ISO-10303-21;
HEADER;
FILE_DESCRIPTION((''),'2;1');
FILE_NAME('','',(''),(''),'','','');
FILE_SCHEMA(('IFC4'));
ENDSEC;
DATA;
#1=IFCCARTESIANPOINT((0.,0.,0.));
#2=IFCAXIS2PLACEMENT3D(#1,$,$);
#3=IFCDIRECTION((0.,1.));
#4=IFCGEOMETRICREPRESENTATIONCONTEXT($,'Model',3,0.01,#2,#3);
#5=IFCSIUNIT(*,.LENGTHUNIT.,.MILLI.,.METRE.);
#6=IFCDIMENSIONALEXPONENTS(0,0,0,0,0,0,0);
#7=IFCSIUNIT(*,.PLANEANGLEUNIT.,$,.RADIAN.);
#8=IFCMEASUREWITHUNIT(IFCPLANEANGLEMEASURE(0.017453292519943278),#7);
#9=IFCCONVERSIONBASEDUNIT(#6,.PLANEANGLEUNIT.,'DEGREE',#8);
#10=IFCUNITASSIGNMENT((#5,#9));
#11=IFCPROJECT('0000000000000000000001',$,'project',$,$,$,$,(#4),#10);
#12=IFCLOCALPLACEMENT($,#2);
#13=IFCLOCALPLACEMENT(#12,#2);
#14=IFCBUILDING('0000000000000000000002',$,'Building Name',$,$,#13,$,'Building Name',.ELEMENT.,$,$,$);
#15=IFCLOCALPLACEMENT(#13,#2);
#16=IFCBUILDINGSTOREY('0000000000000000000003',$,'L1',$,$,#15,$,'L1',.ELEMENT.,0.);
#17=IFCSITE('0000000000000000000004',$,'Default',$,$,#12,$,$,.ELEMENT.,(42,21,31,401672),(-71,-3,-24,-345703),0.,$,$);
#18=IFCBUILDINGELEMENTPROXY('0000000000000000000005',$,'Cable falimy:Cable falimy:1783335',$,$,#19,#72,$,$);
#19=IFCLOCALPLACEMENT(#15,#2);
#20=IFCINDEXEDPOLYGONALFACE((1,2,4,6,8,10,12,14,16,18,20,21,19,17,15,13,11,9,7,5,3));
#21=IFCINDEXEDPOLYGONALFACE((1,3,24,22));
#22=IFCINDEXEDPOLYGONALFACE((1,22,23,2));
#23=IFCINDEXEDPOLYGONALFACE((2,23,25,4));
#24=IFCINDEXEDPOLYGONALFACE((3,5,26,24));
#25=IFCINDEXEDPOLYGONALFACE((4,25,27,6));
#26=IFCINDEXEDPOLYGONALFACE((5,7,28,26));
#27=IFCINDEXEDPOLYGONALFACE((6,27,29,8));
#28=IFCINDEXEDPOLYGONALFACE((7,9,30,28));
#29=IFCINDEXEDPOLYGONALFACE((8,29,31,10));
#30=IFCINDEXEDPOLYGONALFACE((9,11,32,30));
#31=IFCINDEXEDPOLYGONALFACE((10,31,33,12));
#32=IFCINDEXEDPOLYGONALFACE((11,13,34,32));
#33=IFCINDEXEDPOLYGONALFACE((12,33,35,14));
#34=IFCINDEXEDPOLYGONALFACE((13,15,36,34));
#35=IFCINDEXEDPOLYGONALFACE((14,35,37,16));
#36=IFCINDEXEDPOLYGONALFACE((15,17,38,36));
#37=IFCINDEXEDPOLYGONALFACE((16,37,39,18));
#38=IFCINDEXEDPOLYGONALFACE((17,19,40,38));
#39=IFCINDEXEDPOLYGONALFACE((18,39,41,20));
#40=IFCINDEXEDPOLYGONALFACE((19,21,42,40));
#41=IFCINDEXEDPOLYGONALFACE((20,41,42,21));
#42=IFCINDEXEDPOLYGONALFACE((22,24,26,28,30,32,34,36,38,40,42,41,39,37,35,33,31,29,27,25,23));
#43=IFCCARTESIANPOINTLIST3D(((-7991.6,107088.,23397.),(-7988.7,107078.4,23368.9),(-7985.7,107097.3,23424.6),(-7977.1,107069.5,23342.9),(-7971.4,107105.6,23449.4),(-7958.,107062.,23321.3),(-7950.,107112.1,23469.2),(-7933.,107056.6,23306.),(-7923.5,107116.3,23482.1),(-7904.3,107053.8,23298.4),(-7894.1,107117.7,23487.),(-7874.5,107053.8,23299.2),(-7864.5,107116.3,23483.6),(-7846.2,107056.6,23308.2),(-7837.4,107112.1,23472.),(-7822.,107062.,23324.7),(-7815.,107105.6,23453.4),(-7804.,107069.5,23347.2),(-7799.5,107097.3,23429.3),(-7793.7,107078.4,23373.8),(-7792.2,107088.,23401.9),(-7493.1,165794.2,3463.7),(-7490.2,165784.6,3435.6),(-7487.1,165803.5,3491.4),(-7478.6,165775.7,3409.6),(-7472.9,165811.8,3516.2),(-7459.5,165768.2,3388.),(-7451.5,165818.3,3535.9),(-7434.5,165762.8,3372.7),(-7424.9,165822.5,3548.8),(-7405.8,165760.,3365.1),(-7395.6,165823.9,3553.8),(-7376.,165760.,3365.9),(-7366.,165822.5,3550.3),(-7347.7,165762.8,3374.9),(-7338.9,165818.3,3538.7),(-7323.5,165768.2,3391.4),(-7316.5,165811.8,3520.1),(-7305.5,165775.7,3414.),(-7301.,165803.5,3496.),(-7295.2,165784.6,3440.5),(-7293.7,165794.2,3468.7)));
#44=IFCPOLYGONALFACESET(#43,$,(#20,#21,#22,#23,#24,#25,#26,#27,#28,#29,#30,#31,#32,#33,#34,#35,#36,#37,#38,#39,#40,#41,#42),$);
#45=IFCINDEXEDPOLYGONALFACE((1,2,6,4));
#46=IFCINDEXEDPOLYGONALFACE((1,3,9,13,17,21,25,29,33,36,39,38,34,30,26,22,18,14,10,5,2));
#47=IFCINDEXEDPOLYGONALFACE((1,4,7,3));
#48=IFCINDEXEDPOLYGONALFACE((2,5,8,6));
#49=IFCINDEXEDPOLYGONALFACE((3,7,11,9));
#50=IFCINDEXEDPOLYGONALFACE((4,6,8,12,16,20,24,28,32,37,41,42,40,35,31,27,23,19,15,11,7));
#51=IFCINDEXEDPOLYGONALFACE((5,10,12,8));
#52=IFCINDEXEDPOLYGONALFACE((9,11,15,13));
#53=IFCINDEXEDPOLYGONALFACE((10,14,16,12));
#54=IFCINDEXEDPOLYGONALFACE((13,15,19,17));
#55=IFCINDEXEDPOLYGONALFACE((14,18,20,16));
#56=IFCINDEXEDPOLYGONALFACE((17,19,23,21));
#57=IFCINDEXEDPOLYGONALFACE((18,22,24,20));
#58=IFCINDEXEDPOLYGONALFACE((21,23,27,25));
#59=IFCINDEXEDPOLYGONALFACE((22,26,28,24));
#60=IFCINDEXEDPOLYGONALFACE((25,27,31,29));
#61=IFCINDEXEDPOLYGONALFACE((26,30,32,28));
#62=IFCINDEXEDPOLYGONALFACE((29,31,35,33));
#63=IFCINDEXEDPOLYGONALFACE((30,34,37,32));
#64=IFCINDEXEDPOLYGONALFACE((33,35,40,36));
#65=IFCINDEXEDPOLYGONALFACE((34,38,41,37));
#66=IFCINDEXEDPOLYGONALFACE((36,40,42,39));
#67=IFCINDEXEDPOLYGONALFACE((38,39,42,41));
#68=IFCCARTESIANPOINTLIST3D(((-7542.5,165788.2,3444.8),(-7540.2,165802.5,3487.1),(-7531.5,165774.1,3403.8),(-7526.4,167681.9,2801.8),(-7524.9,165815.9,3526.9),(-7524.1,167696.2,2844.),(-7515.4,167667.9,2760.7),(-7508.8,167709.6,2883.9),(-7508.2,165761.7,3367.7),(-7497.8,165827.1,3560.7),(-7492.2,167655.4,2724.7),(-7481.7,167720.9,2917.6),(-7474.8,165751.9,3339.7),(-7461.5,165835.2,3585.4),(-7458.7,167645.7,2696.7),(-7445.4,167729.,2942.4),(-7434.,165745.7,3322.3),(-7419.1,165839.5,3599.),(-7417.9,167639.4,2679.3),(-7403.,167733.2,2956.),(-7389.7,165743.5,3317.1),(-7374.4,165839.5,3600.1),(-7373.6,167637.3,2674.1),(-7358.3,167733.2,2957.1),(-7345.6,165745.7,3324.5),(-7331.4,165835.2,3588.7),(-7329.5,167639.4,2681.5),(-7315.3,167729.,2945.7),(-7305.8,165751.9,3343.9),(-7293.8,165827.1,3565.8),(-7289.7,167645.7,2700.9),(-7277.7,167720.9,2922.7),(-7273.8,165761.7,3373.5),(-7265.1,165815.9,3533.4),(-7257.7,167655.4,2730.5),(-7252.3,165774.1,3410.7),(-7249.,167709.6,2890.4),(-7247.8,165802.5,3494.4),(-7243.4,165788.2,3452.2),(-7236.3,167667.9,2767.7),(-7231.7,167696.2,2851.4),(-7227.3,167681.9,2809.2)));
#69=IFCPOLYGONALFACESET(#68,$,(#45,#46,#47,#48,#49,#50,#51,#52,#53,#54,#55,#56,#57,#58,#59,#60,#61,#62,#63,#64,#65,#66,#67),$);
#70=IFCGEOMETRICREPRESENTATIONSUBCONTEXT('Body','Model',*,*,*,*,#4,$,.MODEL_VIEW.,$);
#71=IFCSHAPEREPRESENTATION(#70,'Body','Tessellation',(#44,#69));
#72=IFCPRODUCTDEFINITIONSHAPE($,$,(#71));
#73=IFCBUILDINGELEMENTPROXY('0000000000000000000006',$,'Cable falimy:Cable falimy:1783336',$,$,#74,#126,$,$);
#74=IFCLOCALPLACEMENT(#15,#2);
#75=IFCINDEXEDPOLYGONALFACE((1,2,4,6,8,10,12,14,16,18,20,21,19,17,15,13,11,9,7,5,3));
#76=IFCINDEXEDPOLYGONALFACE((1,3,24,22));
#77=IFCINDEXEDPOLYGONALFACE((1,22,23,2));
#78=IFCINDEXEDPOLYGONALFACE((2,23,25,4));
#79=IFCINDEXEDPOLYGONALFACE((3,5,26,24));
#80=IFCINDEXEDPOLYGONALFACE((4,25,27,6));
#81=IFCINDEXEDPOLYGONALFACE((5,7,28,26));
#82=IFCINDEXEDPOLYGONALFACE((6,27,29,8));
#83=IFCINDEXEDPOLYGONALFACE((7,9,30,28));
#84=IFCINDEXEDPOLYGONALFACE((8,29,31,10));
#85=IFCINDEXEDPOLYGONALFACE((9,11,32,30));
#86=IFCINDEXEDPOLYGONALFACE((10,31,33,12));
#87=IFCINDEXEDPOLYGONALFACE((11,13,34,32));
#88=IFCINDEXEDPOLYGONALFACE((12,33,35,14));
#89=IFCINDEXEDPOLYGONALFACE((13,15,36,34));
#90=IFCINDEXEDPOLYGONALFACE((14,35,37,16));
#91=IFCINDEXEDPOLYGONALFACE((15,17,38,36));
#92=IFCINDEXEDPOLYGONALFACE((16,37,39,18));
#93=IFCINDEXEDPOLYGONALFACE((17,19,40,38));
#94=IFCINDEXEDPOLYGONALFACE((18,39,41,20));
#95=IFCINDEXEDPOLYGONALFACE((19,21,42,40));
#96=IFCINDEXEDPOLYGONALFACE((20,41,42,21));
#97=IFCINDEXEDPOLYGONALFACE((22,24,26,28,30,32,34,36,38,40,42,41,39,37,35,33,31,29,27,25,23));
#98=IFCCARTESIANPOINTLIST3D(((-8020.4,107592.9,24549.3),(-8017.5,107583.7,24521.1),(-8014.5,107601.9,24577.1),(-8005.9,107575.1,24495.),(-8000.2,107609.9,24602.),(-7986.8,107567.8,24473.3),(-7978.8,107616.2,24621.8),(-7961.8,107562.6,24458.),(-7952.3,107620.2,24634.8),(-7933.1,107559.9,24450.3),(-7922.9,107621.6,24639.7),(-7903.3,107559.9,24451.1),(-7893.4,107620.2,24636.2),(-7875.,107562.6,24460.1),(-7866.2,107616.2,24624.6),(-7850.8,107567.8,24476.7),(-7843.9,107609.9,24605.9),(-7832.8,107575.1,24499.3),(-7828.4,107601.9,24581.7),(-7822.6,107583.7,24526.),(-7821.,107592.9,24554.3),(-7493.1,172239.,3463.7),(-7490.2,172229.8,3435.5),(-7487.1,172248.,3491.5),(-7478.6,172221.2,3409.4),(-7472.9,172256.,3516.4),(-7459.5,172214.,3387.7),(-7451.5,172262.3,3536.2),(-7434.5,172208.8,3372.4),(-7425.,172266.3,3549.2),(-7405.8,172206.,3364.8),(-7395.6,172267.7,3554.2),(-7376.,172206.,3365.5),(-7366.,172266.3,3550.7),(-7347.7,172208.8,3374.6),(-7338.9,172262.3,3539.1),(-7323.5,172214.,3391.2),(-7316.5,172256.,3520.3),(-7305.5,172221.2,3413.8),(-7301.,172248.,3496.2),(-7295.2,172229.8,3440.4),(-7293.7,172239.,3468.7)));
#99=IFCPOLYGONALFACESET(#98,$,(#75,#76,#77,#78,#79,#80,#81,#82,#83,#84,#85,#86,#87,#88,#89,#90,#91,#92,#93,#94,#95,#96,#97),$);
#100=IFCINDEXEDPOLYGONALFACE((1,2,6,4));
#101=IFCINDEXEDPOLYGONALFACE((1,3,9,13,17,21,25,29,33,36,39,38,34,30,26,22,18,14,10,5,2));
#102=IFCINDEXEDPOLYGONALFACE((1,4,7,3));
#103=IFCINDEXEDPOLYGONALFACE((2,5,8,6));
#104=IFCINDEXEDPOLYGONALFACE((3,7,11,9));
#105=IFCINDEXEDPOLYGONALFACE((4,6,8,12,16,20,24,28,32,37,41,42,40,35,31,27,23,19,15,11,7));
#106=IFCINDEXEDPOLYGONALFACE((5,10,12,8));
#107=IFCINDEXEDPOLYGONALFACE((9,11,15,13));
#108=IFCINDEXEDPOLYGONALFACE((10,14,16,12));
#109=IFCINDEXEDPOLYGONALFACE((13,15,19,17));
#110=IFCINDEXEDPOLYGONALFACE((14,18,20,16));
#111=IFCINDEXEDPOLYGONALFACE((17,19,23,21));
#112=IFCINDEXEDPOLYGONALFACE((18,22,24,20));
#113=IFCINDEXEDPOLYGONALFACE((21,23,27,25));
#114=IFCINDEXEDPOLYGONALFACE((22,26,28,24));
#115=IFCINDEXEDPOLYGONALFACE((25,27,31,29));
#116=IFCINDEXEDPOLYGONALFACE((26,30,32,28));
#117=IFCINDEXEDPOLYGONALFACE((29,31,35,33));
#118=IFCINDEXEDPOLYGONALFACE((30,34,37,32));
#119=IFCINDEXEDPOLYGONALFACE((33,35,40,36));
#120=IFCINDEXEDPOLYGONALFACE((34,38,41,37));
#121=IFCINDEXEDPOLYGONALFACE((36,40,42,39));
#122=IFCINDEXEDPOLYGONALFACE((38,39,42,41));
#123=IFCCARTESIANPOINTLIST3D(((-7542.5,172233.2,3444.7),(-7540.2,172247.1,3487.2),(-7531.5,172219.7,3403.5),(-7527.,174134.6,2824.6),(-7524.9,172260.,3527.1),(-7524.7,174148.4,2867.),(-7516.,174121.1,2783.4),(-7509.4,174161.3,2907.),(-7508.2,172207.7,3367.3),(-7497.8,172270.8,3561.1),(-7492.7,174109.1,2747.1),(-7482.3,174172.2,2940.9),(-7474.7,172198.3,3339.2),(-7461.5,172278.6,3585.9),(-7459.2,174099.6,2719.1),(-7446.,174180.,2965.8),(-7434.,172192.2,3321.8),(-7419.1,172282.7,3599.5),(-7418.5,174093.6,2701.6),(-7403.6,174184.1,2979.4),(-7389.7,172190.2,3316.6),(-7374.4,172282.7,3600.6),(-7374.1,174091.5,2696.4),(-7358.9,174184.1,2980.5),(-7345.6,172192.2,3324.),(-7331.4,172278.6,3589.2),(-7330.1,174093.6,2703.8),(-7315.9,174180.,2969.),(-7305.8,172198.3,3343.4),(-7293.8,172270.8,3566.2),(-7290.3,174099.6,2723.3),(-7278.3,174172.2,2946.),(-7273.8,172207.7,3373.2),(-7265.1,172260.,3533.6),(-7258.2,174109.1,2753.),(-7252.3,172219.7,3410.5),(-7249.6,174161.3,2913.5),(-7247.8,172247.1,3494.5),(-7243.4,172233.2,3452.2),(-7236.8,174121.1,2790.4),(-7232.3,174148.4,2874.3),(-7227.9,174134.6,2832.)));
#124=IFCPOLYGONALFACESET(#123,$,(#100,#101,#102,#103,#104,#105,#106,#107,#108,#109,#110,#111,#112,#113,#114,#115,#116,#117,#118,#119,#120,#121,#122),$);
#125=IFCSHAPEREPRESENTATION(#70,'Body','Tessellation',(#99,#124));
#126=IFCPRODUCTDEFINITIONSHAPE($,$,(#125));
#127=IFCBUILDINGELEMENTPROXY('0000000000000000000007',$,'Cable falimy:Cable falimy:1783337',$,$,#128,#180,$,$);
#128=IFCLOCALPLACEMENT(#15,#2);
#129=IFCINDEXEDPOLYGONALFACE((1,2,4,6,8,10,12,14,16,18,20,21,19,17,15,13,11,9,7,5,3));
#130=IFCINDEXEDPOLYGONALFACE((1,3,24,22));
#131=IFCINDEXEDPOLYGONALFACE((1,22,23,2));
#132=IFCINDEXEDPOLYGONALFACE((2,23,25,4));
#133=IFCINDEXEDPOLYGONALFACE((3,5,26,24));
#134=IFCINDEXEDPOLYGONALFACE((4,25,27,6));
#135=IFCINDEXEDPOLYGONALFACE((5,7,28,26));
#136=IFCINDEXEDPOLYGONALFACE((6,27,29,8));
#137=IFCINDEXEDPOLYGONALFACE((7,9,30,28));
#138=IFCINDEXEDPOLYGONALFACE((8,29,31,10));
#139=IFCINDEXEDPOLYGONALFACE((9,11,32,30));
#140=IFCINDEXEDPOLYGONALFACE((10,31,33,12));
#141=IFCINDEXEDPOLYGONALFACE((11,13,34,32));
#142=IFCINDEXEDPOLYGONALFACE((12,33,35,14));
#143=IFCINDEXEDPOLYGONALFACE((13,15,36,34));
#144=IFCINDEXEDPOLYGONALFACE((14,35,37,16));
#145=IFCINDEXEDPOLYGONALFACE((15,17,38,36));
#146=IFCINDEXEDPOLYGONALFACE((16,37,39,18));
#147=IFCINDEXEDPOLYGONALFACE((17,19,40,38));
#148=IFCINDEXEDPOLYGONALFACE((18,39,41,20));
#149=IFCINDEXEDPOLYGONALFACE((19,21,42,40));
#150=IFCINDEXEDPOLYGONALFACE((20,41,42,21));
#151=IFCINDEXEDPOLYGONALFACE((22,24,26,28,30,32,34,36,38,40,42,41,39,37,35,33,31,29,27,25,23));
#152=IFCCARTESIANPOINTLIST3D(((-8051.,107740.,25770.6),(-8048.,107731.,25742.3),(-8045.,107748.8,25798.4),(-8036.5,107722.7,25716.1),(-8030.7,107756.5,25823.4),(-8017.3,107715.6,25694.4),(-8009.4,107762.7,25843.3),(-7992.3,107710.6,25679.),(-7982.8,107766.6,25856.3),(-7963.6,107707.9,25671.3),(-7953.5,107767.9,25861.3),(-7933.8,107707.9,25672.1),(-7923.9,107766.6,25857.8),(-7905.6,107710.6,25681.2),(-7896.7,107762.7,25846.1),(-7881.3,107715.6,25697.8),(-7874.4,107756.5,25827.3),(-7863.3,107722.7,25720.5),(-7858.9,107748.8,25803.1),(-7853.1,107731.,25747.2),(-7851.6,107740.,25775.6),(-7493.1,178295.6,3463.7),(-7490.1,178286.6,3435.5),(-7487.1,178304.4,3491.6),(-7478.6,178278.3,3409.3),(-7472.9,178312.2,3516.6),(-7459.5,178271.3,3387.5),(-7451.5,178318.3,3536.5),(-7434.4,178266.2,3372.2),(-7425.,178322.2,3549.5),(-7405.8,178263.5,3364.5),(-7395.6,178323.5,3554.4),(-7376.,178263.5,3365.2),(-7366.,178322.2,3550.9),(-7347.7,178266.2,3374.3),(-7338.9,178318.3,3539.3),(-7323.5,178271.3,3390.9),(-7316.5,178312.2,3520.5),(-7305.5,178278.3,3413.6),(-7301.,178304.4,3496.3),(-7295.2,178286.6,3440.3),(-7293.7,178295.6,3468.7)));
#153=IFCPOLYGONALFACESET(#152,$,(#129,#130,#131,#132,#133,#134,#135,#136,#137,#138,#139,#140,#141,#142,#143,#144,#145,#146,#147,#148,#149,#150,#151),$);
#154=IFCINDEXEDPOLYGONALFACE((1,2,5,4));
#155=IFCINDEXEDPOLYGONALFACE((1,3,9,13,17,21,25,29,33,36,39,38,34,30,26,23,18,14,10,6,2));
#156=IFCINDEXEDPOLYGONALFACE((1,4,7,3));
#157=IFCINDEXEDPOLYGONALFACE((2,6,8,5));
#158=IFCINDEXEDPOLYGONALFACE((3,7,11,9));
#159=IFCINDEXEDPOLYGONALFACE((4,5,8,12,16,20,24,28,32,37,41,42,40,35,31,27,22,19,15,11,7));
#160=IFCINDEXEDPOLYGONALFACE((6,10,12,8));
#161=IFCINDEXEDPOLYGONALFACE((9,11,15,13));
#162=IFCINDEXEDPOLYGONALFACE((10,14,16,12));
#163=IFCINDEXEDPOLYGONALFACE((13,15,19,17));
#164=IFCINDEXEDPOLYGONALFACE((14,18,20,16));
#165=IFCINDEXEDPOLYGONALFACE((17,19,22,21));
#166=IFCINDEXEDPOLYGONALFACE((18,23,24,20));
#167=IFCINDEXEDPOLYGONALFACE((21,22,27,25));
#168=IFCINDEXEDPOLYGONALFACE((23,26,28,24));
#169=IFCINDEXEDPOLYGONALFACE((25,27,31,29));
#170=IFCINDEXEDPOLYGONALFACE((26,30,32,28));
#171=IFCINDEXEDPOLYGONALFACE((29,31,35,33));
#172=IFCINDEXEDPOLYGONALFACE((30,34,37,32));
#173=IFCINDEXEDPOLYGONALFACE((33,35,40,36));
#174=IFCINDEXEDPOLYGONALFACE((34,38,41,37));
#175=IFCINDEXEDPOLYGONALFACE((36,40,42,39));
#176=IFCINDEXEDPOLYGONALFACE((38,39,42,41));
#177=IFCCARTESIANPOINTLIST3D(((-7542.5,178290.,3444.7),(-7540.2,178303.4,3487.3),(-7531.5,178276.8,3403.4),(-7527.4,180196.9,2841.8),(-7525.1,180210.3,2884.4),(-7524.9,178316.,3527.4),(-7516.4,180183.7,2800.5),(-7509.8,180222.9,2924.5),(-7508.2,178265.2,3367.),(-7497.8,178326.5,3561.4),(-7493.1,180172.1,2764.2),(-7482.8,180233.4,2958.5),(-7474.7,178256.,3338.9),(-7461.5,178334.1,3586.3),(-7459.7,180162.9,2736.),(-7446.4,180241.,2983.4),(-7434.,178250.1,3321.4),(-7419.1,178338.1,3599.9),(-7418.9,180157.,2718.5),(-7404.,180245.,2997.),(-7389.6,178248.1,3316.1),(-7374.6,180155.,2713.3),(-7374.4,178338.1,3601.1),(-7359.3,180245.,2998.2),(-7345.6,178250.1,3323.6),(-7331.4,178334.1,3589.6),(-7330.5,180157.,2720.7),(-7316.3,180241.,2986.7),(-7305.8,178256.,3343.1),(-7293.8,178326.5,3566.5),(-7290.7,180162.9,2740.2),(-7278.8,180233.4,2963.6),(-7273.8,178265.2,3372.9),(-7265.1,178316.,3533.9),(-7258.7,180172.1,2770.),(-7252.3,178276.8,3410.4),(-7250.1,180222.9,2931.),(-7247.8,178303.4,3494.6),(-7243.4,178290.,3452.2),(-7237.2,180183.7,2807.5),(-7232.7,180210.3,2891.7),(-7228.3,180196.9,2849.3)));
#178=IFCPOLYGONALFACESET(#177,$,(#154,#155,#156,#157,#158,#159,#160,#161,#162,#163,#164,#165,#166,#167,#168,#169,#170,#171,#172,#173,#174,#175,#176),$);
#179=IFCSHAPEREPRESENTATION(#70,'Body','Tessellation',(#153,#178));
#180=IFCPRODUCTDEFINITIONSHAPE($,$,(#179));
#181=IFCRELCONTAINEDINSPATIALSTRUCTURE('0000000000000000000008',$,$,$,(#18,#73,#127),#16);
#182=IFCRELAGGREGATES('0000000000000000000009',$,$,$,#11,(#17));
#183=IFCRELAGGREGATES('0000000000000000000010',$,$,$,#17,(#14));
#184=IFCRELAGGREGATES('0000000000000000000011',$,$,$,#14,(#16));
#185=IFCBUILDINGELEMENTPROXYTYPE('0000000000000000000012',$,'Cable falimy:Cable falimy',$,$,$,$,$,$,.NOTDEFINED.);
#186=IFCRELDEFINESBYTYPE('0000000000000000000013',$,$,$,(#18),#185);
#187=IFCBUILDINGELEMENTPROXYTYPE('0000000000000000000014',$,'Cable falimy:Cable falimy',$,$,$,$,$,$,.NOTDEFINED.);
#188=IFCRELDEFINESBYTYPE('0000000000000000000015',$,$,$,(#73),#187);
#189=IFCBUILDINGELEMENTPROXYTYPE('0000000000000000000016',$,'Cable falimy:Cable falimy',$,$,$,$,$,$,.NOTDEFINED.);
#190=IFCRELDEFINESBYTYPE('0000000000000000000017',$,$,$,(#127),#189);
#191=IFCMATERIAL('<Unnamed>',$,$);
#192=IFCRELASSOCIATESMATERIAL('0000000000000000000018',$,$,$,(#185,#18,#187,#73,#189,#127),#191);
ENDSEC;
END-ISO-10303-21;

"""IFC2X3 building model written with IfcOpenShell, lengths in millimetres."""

from ifc_helpers import new_model, entity, si_unit, converted_unit, direction, frame, frame_2d, origin, place, context, subcontext, project, spatial, circle, extrude, source, transform, mapped, material, type_object, type_shapes, element, save


model = new_model("IFC2X3")

# Units and contexts
model_context = context("Model", 3, precision=0.01, world=origin(), true_north=direction((0.0, 1.0)))
body_context = subcontext(model_context, "Body", "Model", "MODEL_VIEW")
ifc_project = project(units=[si_unit("LENGTHUNIT", "METRE", prefix="MILLI"), converted_unit("PLANEANGLEUNIT", "DEGREE", entity("IfcPlaneAngleMeasure", 0.017453292519943278), si_unit("PLANEANGLEUNIT", "RADIAN"), dimensions=[0, 0, 0, 0, 0, 0, 0])], contexts=[model_context])

# Site, building, storey
site_placement = place(None, origin())
site = spatial("IfcSite", under=ifc_project, at=site_placement, Name="Default", CompositionType="ELEMENT", RefLatitude=(42, 21, 31, 401672), RefLongitude=(-71, -3, -24, -345703), RefElevation=0.0)
building_placement = place(site_placement, origin())
building = spatial("IfcBuilding", under=site, at=building_placement, Name="Building Name", LongName="Building Name", CompositionType="ELEMENT")
storey_placement = place(building_placement, origin())
storey = spatial("IfcBuildingStorey", under=building, at=storey_placement, Name="L1", LongName="L1", CompositionType="ELEMENT", Elevation=0.0)

# Shared definitions
ifc_material = material(Name="<Unnamed>")

# Building element proxies
building_element_proxy_type_1 = type_object("IfcBuildingElementProxyType", Name="Cable falimy:Cable falimy", PredefinedType="NOTDEFINED", material=ifc_material)
shared_shape_1 = source(origin(), body_context, "Body", "SweptSolid", [
    extrude(circle(Radius=100.0, at=frame_2d((0.0, 0.0), x_axis=(1.0, 0.0))), frame((0.0, 0.0, 0.0), z_axis=(0.946874, 0.0, 0.321605), x_axis=(-0.321605, 0.0, 0.946874)), (0.0, 0.0, 1.0), 62000.0),
    extrude(circle(Radius=150.0, at=frame_2d((0.0, 0.0), x_axis=(1.0, 0.0))), frame((-1893.7, 0.0, -643.2), z_axis=(0.946874, 0.0, 0.321605), x_axis=(0.321605, 0.0, -0.946874)), (0.0, 0.0, 1.0), 2000.0),
])
type_shapes(building_element_proxy_type_1, [shared_shape_1])
proxy_1_placement = place(storey_placement, frame((-7393.2, 165791.8, 3459.1), z_axis=(-0.025001, 0.0, 0.999687), x_axis=(0.0, -1.0, 0.0)))
element("IfcBuildingElementProxy", 1, at=proxy_1_placement, inside=storey, type_object=building_element_proxy_type_1, material=ifc_material, Name="Cable falimy:Cable falimy:1783335", context=body_context, shape_type="MappedRepresentation", body=[
    mapped(shared_shape_1, transform((0.0, 0.0, 0.0), scale=1.0)),
])
building_element_proxy_type_2 = type_object("IfcBuildingElementProxyType", Name="Cable falimy:Cable falimy", PredefinedType="NOTDEFINED", material=ifc_material)
shared_shape_2 = source(origin(), body_context, "Body", "SweptSolid", [
    extrude(circle(Radius=100.0, at=frame_2d((0.0, 0.0), x_axis=(1.0, 0.0))), frame((0.0, 0.0, 0.0), z_axis=(0.950678, 0.0, 0.310179), x_axis=(-0.310179, 0.0, 0.950678)), (0.0, 0.0, 1.0), 68000.0),
    extrude(circle(Radius=150.0, at=frame_2d((0.0, 0.0), x_axis=(1.0, 0.0))), frame((-1901.4, 0.0, -620.4), z_axis=(0.950678, 0.0, 0.310179), x_axis=(0.310179, 0.0, -0.950678)), (0.0, 0.0, 1.0), 2000.0),
])
type_shapes(building_element_proxy_type_2, [shared_shape_2])
proxy_2_placement = place(storey_placement, frame((-7393.2, 172236.7, 3459.1), z_axis=(-0.025001, 0.0, 0.999687), x_axis=(0.0, -1.0, 0.0)))
element("IfcBuildingElementProxy", 2, at=proxy_2_placement, inside=storey, type_object=building_element_proxy_type_2, material=ifc_material, Name="Cable falimy:Cable falimy:1783336", context=body_context, shape_type="MappedRepresentation", body=[
    mapped(shared_shape_2, transform((0.0, 0.0, 0.0), scale=1.0)),
])
building_element_proxy_type_3 = type_object("IfcBuildingElementProxyType", Name="Cable falimy:Cable falimy", PredefinedType="NOTDEFINED", material=ifc_material)
shared_shape_3 = source(origin(), body_context, "Body", "SweptSolid", [
    extrude(circle(Radius=100.0, at=frame_2d((0.0, 0.0), x_axis=(1.0, 0.0))), frame((0.0, 0.0, 0.0), z_axis=(0.953454, 0.0, 0.301538), x_axis=(-0.301538, 0.0, 0.953454)), (0.0, 0.0, 1.0), 74000.0),
    extrude(circle(Radius=150.0, at=frame_2d((0.0, 0.0), x_axis=(1.0, 0.0))), frame((-1906.9, 0.0, -603.1), z_axis=(0.953454, 0.0, 0.301538), x_axis=(0.301538, 0.0, -0.953454)), (0.0, 0.0, 1.0), 2000.0),
])
type_shapes(building_element_proxy_type_3, [shared_shape_3])
proxy_3_placement = place(storey_placement, frame((-7393.2, 178293.4, 3459.1), z_axis=(-0.025001, 0.0, 0.999687), x_axis=(0.0, -1.0, 0.0)))
element("IfcBuildingElementProxy", 3, at=proxy_3_placement, inside=storey, type_object=building_element_proxy_type_3, material=ifc_material, Name="Cable falimy:Cable falimy:1783337", context=body_context, shape_type="MappedRepresentation", body=[
    mapped(shared_shape_3, transform((0.0, 0.0, 0.0), scale=1.0)),
])

save(model, "model.ifc")
